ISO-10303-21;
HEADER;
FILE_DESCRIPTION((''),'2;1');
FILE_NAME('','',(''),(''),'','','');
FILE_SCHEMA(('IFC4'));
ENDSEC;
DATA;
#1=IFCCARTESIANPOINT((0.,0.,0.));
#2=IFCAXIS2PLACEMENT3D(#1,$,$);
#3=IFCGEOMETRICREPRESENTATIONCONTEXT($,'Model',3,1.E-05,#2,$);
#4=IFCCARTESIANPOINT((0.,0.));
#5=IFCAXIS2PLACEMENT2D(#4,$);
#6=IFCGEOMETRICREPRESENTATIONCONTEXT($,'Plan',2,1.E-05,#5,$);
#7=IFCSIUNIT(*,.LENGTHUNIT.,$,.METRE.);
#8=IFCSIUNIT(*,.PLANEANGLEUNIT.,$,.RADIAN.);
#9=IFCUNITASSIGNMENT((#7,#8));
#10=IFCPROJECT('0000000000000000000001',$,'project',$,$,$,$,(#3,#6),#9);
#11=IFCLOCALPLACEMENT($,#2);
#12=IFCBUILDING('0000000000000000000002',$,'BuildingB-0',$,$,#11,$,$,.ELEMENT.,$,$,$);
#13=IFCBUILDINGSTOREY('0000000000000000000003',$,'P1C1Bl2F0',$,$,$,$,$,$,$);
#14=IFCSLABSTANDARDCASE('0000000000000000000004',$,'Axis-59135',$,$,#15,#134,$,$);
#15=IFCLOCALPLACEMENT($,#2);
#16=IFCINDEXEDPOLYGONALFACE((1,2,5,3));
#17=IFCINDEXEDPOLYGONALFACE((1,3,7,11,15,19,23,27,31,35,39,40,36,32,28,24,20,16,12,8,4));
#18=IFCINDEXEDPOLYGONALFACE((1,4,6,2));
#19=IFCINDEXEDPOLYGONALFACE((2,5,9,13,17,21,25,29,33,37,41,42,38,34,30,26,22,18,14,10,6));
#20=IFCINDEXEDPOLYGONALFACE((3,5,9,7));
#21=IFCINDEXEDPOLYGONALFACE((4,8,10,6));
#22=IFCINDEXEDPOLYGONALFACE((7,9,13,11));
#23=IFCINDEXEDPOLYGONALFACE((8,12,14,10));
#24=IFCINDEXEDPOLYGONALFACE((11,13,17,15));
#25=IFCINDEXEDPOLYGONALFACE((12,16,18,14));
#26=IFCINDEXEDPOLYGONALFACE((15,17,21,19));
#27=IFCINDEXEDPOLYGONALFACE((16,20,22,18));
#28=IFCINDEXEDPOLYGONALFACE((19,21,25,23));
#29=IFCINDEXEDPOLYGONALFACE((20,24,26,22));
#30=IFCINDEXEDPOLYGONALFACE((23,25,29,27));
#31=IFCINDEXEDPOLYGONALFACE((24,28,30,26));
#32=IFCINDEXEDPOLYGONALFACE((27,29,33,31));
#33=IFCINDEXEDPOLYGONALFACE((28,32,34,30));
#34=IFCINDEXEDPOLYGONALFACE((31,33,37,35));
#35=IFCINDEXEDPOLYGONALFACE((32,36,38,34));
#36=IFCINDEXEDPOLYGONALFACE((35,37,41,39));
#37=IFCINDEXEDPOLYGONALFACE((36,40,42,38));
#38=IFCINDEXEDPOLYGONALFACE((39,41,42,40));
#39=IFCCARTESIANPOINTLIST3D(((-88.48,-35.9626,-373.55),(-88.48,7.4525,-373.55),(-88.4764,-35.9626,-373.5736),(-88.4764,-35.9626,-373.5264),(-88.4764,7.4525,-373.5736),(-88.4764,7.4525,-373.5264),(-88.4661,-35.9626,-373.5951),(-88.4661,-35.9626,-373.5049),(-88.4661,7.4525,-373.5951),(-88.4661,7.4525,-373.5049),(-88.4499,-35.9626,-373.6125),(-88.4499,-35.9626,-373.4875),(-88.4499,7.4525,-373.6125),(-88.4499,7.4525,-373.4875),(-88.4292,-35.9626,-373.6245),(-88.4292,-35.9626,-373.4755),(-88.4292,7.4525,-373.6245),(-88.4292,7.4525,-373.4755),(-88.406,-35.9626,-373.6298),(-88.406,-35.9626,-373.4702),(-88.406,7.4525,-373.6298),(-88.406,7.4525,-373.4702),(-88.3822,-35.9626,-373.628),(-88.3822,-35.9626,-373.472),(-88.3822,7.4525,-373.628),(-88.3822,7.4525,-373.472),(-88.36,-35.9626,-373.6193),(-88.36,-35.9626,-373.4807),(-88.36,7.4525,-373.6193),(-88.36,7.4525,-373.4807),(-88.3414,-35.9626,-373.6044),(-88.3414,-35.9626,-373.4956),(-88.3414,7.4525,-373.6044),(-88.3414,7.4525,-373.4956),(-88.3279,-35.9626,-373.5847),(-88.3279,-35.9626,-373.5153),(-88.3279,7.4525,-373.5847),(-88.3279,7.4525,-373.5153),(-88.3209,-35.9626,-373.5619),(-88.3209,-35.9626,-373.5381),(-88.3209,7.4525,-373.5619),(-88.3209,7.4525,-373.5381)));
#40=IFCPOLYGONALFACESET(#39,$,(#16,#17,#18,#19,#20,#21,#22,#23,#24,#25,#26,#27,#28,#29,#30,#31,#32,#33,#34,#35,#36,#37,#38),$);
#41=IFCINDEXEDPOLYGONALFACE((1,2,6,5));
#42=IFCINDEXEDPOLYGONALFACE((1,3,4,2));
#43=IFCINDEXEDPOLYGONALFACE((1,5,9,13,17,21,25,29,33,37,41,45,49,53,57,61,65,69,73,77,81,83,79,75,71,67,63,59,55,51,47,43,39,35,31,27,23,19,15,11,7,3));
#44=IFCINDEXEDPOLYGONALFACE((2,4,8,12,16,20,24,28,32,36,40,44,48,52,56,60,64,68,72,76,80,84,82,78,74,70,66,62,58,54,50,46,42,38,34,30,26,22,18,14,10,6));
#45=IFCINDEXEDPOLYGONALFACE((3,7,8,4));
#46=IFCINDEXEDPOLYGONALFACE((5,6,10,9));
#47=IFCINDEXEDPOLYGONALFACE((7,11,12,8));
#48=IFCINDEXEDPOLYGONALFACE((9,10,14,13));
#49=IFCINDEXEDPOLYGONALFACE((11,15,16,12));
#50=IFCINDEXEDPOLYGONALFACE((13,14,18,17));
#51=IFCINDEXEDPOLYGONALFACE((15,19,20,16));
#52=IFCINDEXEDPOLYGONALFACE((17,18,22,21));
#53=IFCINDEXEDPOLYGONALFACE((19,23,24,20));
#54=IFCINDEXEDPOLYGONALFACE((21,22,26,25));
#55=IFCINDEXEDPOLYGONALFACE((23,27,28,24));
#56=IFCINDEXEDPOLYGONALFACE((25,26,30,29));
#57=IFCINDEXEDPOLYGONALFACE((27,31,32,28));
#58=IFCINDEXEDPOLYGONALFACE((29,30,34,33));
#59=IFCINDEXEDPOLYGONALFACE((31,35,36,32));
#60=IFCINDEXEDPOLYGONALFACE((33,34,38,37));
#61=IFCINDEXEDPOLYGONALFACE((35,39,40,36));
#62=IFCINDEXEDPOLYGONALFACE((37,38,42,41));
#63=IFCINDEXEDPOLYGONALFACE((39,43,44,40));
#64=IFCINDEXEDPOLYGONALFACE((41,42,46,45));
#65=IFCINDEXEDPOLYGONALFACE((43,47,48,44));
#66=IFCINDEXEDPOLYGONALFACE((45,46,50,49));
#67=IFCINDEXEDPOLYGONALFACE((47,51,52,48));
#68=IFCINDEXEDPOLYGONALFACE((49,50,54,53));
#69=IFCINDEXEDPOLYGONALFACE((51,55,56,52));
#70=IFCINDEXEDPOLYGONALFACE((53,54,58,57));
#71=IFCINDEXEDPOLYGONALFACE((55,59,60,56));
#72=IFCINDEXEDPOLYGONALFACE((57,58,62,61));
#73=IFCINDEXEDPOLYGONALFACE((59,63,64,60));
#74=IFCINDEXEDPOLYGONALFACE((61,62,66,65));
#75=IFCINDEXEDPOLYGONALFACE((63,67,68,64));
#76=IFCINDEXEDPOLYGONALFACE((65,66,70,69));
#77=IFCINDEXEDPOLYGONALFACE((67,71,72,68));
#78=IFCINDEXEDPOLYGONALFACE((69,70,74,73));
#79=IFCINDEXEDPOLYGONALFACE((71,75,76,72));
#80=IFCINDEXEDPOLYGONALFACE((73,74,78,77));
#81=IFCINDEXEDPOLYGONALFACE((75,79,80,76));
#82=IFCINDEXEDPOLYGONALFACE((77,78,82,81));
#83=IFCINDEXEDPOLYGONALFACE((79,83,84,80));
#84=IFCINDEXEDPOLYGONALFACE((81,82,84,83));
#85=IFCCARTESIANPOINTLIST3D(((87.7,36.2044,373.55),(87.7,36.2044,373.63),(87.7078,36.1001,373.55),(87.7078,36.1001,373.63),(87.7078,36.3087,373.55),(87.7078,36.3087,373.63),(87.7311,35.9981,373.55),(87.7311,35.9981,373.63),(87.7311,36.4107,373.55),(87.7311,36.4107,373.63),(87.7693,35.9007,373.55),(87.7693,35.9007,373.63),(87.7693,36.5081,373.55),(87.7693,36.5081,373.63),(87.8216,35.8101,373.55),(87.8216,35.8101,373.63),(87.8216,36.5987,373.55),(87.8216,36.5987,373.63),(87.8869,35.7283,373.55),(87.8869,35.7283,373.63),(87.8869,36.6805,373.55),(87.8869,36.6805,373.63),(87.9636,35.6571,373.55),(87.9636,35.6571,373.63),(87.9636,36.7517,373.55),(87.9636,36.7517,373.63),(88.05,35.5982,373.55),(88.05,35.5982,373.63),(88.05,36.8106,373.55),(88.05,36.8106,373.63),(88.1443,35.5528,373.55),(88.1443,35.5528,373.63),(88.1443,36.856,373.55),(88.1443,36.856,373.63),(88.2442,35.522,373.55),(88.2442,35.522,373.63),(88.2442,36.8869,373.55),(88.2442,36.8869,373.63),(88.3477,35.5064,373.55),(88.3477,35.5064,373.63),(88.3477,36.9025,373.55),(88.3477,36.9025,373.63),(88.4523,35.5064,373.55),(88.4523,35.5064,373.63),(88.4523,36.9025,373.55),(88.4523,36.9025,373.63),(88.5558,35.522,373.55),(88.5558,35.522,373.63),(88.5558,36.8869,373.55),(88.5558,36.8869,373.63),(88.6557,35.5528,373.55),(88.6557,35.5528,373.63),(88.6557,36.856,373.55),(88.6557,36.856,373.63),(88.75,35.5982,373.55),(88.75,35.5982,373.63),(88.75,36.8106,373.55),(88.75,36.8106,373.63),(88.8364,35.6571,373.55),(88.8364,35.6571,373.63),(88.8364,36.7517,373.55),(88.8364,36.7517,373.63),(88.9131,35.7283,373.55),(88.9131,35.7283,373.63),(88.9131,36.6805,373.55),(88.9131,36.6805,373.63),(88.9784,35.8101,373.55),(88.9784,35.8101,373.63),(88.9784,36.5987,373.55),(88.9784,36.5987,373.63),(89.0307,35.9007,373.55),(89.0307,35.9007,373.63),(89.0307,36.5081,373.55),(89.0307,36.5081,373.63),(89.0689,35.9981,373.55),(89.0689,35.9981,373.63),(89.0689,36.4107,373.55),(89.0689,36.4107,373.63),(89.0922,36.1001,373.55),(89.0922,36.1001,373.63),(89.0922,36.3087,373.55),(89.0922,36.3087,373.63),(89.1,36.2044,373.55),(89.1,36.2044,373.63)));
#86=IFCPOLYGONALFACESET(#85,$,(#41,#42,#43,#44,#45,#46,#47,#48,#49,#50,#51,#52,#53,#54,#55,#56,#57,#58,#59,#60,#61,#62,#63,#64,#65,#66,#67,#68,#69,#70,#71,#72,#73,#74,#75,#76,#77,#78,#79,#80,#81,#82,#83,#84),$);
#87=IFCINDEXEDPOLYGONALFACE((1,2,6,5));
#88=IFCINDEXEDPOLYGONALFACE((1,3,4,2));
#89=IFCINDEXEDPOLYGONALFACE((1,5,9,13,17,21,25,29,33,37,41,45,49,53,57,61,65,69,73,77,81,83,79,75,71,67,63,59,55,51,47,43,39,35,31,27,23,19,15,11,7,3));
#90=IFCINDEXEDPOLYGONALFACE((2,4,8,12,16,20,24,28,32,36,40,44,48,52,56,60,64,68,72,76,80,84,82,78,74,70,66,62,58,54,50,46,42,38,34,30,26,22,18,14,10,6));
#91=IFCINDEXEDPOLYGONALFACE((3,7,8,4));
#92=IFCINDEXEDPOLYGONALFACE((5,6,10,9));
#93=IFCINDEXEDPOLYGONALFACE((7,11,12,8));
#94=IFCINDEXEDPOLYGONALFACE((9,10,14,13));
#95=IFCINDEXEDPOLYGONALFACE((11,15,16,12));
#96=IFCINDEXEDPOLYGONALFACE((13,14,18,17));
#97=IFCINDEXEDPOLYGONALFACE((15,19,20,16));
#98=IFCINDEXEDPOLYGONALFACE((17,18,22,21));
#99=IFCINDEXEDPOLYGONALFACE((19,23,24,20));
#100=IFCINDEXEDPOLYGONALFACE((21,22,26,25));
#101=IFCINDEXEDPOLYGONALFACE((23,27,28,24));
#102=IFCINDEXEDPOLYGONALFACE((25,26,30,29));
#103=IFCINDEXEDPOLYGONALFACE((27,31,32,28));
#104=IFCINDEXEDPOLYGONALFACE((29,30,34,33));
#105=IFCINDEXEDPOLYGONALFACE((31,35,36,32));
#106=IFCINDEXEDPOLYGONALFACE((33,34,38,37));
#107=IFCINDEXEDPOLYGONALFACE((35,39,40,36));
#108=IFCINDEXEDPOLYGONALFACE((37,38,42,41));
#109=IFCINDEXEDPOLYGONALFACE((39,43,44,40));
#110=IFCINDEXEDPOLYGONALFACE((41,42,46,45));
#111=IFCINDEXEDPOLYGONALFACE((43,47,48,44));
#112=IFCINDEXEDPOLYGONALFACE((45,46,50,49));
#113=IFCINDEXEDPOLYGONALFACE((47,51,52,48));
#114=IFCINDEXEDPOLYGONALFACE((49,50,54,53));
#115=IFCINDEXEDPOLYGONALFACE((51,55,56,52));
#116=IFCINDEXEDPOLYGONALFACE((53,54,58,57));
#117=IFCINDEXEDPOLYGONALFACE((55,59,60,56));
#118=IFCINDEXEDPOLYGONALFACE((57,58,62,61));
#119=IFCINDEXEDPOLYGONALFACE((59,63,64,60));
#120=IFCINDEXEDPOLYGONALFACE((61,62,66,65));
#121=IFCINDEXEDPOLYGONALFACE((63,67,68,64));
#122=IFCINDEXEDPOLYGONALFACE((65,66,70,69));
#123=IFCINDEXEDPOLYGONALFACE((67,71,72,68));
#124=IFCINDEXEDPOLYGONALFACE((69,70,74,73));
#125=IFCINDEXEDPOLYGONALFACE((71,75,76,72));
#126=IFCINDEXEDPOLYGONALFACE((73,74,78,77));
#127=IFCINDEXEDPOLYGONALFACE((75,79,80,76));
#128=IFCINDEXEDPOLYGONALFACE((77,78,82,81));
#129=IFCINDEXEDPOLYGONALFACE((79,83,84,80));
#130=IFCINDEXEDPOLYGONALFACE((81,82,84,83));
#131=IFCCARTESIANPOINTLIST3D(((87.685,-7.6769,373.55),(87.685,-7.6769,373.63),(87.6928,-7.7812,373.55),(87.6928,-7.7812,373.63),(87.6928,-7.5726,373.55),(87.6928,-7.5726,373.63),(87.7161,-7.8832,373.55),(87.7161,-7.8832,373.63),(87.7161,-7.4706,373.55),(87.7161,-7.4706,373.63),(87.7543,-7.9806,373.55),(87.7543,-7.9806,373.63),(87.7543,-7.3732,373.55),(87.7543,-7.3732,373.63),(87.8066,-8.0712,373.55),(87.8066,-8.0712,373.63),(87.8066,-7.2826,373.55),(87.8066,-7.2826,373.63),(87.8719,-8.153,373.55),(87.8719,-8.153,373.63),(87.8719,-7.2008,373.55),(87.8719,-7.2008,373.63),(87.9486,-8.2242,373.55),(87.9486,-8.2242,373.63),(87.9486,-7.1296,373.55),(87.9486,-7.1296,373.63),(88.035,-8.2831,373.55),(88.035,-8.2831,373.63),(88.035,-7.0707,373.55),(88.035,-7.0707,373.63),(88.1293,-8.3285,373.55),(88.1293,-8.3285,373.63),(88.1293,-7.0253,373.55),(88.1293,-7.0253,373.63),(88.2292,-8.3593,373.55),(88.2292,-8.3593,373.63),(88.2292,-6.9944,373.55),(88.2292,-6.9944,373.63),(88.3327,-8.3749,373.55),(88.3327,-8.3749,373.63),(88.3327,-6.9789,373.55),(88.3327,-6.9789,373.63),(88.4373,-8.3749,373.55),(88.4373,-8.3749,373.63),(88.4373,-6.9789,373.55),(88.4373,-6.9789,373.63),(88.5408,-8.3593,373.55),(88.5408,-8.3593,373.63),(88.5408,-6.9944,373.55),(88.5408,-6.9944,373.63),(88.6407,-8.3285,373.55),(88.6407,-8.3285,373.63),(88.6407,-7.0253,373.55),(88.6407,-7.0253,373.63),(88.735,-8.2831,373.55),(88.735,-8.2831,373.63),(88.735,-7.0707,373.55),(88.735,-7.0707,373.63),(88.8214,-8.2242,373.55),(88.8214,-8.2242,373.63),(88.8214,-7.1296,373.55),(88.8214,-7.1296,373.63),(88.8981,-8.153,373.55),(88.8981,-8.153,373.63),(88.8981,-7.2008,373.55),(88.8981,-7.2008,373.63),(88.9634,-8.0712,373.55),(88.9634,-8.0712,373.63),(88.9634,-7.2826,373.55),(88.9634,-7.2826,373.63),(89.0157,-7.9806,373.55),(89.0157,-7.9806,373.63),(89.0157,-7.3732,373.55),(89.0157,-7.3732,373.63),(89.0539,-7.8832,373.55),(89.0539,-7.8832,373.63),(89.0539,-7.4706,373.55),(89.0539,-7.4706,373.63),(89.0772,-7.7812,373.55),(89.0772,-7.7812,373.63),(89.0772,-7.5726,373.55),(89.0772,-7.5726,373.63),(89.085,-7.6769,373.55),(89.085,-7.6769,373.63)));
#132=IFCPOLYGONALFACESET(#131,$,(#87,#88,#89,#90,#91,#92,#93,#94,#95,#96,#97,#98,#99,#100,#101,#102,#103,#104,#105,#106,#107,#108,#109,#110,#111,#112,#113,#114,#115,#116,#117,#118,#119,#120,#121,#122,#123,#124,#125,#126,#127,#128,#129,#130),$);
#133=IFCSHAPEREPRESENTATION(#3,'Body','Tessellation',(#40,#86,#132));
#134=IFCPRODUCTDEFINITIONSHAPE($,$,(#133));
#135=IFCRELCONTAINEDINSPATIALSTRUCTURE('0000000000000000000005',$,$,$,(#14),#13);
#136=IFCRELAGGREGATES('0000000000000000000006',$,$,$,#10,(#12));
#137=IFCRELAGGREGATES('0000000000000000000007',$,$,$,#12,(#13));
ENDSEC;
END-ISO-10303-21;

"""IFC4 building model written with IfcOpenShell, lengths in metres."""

from ifc_helpers import new_model, entity, si_unit, frame, origin, origin_2d, place, context, project, spatial, circle, extrude, element, save


model = new_model("IFC4")

# Units and contexts
model_context = context("Model", 3, precision=1e-05, world=origin())
plan_context = context("Plan", 2, precision=1e-05, world=origin_2d())
ifc_project = project(units=[si_unit("LENGTHUNIT", "METRE"), si_unit("PLANEANGLEUNIT", "RADIAN")], contexts=[model_context, plan_context])

# Building, storey
building_placement = place(None, origin())
building = spatial("IfcBuilding", under=ifc_project, at=building_placement, Name="BuildingB-0", CompositionType="ELEMENT")
storey = spatial("IfcBuildingStorey", under=building, Name="P1C1Bl2F0")

# Slab
element("IfcSlabStandardCase", 1, inside=storey, Name="Axis-59135", context=model_context, shape_type="AdvancedSweptSolid", body=[
    entity("IfcSurfaceCurveSweptAreaSolid", entity("IfcCircleProfileDef", "AREA", None, None, 0.08), None, entity("IfcPolyline", [entity("IfcCartesianPoint", [88.4, 35.9626, 373.55]), entity("IfcCartesianPoint", [88.4, -7.4525, 373.55])]), None, None, entity("IfcPlane", entity("IfcAxis2Placement3D", entity("IfcCartesianPoint", [88.4, 35.9626, 373.55]), entity("IfcDirection", [0.0, 0.0, 1.0]), entity("IfcDirection", [1.0, 0.0, 0.0])))),
    extrude(circle(Radius=0.7), frame((88.4, 36.2044, 373.55)), (0.0, 0.0, 1.0), 0.08),
    extrude(circle(Radius=0.7), frame((88.385, -7.6769, 373.55)), (0.0, 0.0, 1.0), 0.08),
])

save(model, "model.ifc")
